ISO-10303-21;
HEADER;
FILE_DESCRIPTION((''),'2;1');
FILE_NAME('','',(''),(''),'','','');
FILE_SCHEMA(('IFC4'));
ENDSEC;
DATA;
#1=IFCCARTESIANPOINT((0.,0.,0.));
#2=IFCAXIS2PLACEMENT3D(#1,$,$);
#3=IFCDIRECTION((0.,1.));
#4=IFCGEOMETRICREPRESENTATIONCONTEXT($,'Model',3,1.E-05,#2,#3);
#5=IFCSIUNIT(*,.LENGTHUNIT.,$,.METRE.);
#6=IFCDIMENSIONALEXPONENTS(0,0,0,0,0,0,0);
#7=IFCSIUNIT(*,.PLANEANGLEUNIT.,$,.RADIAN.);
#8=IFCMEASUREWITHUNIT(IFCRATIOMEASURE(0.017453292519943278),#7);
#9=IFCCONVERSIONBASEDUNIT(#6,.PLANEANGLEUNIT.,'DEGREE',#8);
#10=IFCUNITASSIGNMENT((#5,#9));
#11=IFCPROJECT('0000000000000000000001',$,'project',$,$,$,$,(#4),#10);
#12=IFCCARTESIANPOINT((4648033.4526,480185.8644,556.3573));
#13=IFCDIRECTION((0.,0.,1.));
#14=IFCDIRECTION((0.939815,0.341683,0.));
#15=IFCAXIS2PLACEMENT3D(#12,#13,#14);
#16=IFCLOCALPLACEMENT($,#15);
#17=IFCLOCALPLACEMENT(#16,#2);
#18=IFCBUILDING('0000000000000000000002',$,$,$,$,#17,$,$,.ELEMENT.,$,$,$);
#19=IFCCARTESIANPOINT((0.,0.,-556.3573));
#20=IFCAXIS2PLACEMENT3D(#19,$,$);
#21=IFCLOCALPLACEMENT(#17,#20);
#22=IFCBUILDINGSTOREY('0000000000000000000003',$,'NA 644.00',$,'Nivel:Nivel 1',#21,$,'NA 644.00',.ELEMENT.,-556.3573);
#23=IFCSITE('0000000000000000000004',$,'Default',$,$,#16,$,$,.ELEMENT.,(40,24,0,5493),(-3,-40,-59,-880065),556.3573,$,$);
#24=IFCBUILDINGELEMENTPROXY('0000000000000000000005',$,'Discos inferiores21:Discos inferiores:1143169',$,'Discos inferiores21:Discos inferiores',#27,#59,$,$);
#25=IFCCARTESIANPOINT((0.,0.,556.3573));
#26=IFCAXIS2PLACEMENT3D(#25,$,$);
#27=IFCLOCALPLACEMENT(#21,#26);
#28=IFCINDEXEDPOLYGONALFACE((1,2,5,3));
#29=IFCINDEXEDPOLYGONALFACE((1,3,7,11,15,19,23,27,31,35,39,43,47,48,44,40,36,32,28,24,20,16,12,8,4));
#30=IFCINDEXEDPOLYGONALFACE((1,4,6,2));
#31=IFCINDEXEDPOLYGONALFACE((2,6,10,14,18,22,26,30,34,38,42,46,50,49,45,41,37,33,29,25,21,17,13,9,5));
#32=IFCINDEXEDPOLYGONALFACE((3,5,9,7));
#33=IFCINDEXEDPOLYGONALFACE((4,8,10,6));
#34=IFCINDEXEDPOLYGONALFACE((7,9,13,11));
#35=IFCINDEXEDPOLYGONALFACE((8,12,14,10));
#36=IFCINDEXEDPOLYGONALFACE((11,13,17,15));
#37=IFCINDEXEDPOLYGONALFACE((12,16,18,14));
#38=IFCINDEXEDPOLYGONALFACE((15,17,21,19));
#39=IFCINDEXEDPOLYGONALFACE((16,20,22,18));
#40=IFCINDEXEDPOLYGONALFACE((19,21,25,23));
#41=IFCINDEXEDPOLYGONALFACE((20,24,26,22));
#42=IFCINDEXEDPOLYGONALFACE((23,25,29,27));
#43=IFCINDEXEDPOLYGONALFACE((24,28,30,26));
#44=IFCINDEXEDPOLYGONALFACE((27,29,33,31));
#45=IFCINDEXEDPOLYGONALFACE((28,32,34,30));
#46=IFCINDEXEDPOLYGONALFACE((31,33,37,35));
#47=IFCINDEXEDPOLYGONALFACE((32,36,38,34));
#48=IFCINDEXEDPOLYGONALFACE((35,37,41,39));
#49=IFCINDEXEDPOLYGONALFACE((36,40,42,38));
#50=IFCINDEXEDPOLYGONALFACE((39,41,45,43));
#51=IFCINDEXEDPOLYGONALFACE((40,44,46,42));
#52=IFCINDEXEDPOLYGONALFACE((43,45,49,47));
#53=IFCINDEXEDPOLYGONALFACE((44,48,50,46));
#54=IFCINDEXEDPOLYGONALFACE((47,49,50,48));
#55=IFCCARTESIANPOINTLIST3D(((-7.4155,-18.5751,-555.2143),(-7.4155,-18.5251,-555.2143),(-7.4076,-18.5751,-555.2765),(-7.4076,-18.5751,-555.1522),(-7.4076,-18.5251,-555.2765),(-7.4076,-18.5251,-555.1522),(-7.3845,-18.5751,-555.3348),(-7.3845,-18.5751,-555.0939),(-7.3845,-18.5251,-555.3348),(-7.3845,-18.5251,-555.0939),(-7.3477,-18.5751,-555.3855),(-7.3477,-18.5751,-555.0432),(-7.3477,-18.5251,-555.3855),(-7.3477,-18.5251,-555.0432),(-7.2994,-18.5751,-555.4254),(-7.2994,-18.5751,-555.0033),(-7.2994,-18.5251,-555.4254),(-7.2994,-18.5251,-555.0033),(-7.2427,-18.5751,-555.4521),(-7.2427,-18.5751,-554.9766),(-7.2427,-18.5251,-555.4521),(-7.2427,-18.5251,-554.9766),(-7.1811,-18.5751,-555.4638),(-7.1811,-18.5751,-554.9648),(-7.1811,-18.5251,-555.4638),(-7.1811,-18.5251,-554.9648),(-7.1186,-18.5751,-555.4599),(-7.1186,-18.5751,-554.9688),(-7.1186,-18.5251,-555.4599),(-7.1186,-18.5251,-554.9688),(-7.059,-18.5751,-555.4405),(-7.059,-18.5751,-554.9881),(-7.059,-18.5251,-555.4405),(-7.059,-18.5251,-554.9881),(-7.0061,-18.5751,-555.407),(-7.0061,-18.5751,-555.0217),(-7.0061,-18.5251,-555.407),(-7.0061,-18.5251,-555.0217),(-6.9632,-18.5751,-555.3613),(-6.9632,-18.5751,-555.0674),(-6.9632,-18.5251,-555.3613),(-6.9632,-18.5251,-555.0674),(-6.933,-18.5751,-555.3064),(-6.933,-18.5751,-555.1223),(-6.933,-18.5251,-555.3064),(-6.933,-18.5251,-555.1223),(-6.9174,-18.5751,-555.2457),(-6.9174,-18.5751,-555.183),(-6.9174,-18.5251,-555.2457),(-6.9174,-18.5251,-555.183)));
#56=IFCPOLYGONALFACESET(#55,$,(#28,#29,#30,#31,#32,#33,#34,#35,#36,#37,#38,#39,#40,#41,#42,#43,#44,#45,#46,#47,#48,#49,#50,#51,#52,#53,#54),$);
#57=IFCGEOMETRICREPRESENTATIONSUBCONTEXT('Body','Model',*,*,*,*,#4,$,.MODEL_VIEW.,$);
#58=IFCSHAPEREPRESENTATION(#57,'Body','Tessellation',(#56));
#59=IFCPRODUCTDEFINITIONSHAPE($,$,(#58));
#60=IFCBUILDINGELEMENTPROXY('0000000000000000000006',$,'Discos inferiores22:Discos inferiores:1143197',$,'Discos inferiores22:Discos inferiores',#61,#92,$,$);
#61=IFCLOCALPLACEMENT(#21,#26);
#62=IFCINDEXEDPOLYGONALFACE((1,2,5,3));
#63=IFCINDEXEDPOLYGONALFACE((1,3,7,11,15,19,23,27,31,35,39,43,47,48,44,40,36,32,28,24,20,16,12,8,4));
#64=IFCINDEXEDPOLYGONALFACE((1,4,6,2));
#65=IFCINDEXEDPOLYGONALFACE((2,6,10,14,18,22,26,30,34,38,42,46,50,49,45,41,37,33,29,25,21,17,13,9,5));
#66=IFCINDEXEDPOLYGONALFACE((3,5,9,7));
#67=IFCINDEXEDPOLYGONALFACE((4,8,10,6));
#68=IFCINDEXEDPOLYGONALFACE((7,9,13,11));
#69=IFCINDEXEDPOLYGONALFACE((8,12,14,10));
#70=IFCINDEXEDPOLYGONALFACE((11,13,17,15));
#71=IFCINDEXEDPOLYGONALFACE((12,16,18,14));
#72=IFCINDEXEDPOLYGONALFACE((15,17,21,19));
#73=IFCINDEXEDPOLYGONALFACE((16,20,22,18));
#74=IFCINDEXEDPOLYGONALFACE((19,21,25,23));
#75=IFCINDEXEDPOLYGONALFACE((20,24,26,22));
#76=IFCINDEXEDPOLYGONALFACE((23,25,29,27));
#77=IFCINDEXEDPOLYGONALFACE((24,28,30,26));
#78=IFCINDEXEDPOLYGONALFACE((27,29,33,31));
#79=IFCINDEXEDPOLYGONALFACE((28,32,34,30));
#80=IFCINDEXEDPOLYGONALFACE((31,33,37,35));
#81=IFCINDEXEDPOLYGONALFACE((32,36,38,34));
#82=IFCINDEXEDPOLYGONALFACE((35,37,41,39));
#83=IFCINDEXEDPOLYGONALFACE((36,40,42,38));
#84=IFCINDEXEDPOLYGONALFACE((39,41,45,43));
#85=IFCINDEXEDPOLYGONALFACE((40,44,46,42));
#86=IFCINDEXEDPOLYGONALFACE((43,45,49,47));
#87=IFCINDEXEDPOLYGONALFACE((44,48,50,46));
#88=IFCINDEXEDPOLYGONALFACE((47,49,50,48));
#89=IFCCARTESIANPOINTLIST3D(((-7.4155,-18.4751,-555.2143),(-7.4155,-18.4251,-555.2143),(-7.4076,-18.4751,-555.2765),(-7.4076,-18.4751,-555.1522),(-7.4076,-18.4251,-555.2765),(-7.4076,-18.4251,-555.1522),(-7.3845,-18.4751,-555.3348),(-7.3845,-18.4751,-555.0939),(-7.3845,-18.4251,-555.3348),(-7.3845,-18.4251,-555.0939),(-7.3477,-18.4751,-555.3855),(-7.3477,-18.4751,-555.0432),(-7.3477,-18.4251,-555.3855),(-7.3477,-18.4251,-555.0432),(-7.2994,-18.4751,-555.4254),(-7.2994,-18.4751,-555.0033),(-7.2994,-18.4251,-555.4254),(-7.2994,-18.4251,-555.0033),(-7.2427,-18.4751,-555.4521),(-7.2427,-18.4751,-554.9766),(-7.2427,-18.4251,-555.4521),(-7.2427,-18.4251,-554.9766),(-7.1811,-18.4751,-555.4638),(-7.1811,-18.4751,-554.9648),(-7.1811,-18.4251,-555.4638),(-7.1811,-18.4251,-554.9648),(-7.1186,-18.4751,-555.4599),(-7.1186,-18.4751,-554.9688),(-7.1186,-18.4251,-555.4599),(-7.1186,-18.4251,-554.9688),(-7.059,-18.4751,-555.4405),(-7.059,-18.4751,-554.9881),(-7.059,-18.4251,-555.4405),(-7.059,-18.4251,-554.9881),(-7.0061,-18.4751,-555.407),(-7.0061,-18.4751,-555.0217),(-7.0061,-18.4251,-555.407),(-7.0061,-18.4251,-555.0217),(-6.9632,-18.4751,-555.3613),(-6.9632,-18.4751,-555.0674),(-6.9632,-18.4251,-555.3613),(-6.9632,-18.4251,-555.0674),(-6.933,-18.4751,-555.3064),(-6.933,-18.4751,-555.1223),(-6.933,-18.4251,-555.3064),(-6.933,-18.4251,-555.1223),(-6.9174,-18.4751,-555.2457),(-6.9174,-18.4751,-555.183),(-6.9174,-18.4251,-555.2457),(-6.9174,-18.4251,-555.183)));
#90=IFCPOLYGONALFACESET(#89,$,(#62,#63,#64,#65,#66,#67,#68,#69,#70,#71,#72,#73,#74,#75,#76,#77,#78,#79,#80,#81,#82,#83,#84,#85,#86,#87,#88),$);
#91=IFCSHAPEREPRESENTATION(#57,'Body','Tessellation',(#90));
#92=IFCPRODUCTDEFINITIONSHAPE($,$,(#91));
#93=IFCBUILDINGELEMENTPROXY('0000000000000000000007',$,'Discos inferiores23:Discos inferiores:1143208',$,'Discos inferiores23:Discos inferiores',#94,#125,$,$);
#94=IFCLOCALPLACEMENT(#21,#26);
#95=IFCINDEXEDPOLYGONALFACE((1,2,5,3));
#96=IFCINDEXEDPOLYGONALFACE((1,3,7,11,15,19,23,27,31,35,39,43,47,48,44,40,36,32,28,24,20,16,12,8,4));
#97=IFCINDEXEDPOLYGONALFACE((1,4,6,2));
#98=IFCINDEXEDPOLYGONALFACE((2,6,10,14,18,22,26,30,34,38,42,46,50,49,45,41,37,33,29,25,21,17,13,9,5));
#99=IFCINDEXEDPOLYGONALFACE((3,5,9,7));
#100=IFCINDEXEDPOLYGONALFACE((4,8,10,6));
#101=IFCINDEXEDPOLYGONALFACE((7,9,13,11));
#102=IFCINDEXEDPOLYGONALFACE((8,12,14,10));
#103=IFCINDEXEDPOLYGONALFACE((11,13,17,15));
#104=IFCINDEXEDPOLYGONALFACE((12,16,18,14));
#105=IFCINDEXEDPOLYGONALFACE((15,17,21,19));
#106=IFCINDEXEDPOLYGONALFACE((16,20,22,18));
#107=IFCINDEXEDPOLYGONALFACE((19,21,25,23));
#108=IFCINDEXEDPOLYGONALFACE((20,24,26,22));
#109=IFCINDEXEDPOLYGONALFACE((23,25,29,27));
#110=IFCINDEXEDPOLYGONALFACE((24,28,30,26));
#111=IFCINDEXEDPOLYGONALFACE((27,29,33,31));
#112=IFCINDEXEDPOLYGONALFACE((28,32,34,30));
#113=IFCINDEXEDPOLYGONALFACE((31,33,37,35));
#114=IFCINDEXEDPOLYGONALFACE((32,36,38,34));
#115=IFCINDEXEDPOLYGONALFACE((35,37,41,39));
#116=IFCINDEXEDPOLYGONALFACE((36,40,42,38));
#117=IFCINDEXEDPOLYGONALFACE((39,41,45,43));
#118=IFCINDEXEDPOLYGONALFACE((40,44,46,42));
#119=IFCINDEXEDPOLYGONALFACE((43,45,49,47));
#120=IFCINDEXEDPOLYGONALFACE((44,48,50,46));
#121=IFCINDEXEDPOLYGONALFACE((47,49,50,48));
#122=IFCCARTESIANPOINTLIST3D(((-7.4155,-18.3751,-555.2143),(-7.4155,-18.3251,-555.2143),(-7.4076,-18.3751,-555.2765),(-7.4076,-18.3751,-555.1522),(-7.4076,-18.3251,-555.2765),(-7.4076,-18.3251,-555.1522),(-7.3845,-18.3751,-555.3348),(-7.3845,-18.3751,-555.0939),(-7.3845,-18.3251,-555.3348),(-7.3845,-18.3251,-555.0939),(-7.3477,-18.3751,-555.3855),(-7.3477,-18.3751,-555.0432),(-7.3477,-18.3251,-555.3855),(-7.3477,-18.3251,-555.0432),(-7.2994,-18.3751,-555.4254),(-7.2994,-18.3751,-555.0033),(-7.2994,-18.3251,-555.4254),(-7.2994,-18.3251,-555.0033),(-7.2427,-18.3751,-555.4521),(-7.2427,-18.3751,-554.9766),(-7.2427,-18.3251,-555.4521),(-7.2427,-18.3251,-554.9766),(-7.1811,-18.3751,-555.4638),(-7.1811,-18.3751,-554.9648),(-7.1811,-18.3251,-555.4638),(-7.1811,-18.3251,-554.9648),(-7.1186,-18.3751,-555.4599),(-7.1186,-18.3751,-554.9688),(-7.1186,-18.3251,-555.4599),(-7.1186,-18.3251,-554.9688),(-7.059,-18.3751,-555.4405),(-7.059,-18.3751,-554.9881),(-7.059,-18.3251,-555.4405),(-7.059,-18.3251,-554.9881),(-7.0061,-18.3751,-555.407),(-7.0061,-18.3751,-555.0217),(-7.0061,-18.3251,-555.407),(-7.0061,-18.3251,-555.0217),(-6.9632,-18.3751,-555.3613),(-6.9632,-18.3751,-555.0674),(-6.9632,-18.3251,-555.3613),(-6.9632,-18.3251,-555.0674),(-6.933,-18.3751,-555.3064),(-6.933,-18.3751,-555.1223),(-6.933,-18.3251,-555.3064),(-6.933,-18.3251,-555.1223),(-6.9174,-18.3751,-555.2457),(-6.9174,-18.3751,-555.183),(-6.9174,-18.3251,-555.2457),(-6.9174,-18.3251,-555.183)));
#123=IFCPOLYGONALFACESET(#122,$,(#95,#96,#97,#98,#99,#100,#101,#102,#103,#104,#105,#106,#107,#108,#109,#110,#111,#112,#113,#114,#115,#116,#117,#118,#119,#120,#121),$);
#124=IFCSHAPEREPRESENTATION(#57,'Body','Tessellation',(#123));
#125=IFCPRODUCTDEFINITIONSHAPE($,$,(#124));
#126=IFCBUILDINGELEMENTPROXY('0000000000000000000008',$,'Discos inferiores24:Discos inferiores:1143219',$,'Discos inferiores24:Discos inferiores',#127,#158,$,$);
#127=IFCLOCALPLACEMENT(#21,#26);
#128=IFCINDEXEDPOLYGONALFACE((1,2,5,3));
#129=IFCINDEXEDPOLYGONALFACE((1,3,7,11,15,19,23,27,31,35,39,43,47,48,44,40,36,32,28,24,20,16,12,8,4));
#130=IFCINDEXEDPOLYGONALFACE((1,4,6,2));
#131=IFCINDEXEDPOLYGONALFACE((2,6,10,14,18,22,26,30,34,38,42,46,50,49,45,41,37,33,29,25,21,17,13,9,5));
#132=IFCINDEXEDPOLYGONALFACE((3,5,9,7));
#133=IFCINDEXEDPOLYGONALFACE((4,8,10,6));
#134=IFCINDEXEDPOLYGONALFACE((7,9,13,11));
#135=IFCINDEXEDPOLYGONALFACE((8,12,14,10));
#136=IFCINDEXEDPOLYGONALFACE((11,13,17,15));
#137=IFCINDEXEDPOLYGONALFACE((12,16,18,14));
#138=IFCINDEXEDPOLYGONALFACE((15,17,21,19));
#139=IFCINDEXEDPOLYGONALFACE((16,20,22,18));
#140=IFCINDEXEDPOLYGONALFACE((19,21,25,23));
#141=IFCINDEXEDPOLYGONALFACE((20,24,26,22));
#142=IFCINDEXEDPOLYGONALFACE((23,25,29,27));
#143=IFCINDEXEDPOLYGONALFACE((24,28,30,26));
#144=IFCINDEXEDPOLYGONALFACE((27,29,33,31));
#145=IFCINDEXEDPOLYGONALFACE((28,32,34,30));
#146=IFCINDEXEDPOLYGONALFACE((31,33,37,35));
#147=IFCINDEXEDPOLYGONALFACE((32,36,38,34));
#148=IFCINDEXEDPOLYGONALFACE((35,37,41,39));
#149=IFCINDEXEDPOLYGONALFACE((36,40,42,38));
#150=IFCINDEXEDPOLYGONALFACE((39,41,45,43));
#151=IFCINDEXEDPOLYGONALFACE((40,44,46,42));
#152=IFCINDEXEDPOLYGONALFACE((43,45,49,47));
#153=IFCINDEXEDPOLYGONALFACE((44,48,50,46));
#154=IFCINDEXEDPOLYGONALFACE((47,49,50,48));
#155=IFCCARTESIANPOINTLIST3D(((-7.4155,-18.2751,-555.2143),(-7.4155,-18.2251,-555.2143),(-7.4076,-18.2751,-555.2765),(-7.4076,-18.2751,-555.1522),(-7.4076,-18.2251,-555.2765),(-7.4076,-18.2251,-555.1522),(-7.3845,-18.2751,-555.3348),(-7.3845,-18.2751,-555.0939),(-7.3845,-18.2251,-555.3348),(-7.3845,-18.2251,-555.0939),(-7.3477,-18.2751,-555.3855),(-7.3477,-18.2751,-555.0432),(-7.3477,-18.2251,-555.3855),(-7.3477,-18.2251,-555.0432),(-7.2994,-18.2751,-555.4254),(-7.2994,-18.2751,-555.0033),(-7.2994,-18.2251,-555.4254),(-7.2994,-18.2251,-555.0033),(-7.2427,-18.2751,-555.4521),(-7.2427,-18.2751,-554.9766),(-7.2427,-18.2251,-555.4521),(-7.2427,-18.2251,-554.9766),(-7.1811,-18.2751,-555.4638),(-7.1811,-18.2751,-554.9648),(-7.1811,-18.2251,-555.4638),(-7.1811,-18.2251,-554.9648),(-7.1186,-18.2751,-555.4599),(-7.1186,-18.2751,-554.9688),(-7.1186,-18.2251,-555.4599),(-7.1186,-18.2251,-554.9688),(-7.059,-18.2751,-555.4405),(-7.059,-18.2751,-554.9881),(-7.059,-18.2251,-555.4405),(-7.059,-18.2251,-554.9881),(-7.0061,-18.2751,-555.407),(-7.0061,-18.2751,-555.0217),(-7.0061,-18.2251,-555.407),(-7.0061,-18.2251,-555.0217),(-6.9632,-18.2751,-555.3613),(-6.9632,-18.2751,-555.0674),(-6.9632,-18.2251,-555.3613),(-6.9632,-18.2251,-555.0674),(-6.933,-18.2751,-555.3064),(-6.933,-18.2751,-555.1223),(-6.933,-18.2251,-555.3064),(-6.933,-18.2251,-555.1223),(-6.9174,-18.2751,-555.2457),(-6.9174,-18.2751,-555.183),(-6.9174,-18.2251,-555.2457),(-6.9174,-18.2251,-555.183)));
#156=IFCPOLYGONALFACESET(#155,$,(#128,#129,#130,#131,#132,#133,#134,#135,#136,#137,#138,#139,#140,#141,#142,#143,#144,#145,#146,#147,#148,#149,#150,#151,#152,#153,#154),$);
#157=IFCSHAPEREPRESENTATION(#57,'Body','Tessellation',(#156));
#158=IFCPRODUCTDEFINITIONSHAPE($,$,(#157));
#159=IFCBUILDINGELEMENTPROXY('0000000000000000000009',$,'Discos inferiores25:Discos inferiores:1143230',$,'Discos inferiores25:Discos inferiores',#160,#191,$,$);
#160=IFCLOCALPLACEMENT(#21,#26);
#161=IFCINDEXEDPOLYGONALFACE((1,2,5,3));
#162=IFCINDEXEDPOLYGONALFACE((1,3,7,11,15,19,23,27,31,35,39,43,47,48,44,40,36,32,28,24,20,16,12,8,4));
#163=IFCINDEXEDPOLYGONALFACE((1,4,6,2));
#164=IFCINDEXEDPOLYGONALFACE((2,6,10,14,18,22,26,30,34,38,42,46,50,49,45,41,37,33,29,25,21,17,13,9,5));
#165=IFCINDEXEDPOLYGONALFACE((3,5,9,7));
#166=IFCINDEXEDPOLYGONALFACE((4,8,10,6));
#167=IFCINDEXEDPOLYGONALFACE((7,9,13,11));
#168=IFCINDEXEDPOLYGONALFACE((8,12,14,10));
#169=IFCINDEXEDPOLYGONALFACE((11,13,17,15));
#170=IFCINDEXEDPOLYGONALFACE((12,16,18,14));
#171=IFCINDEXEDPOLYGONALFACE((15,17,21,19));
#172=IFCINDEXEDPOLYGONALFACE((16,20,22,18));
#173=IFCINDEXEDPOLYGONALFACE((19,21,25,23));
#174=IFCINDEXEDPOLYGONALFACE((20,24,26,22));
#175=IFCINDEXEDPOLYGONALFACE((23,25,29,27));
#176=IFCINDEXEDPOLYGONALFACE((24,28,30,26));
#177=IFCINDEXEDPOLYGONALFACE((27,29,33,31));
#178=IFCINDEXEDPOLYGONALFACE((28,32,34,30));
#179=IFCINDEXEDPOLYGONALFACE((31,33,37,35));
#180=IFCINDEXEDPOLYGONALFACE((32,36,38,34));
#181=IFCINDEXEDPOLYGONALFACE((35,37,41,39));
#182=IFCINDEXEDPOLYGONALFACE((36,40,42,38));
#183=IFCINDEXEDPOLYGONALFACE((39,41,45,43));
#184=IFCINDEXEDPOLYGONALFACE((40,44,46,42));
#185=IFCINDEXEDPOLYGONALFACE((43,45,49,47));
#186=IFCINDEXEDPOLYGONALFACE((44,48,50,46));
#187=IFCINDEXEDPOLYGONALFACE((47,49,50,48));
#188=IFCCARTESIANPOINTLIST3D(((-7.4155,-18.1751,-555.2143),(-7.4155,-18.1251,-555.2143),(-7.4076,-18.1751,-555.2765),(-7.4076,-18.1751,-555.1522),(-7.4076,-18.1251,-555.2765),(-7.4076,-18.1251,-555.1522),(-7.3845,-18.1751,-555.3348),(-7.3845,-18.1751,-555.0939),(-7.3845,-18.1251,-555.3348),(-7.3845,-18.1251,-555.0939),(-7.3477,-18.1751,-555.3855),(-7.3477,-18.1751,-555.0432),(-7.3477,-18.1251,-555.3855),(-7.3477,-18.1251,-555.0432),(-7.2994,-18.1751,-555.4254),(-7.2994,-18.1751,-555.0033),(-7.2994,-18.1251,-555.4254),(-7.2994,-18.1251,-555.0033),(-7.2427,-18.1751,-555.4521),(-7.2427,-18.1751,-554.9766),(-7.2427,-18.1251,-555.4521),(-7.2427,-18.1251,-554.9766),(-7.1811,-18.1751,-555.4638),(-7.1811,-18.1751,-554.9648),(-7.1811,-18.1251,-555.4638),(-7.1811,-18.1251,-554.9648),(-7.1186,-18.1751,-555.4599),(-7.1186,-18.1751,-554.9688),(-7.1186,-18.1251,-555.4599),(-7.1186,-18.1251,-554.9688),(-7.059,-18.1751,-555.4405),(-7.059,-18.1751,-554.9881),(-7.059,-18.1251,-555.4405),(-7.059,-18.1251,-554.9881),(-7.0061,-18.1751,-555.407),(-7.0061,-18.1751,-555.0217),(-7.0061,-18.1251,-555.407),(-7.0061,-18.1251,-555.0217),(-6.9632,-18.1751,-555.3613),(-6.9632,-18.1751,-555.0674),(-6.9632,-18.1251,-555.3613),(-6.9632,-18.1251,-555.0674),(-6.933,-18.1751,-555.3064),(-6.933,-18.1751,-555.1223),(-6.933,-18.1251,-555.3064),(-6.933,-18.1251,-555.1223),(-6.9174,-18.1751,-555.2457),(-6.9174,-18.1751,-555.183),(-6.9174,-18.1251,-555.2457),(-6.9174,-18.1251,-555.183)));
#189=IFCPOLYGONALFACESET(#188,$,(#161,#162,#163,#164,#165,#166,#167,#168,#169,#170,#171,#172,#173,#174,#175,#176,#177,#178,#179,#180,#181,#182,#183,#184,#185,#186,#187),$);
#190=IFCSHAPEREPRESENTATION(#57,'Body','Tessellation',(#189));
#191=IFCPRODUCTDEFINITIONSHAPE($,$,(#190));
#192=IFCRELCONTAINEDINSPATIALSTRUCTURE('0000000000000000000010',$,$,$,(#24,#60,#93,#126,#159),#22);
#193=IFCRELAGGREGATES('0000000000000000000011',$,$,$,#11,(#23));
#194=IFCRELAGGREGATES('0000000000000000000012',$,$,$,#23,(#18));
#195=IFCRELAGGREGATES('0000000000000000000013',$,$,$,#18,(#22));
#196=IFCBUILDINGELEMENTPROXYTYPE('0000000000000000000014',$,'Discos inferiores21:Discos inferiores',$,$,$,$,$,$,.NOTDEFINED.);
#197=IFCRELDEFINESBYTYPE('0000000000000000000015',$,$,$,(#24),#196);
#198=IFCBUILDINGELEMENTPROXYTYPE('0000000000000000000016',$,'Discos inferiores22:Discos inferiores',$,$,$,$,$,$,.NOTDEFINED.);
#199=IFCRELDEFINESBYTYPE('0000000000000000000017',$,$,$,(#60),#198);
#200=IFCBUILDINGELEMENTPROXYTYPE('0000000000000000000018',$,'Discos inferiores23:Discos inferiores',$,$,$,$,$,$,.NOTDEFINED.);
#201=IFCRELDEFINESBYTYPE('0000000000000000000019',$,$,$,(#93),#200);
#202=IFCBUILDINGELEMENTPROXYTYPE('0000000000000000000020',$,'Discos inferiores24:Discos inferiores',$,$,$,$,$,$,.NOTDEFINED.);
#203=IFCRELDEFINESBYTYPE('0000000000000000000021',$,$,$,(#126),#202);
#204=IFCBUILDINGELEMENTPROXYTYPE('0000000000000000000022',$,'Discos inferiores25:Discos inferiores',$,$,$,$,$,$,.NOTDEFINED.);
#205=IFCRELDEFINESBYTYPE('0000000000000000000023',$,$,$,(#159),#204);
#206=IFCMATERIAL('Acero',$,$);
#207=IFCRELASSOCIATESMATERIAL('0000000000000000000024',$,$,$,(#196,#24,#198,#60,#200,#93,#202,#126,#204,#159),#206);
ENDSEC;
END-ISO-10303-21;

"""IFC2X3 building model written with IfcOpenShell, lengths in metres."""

from ifc_helpers import new_model, entity, si_unit, converted_unit, direction, frame, origin, origin_2d_with_axis, place, context, subcontext, project, spatial, circle, extrude, source, transform, mapped, material, type_object, type_shapes, element, save


model = new_model("IFC2X3")

# Units and contexts
model_context = context("Model", 3, precision=1e-05, world=origin(), true_north=direction((0.0, 1.0)))
body_context = subcontext(model_context, "Body", "Model", "MODEL_VIEW")
ifc_project = project(units=[si_unit("LENGTHUNIT", "METRE"), converted_unit("PLANEANGLEUNIT", "DEGREE", entity("IfcRatioMeasure", 0.017453292519943278), si_unit("PLANEANGLEUNIT", "RADIAN"), dimensions=[0, 0, 0, 0, 0, 0, 0])], contexts=[model_context])

# Site, building, storey
site_placement = place(None, frame((4648033.4526, 480185.8644, 556.3573), z_axis=(0.0, 0.0, 1.0), x_axis=(0.939815, 0.341683, 0.0)))
site = spatial("IfcSite", under=ifc_project, at=site_placement, Name="Default", CompositionType="ELEMENT", RefLatitude=(40, 24, 0, 5493), RefLongitude=(-3, -40, -59, -880065), RefElevation=556.3573)
building_placement = place(site_placement, origin())
building = spatial("IfcBuilding", under=site, at=building_placement, CompositionType="ELEMENT")
storey_placement = place(building_placement, frame((0.0, 0.0, -556.3573)))
storey = spatial("IfcBuildingStorey", under=building, at=storey_placement, Name="NA 644.00", ObjectType="Nivel:Nivel 1", LongName="NA 644.00", CompositionType="ELEMENT", Elevation=-556.3573)

# Building element proxies
ifc_material_1 = material(Name="Acero")
building_element_proxy_type_1 = type_object("IfcBuildingElementProxyType", Name="Discos inferiores21:Discos inferiores", PredefinedType="NOTDEFINED", material=ifc_material_1)
shared_shape_1 = source(origin(), body_context, "Body", "SweptSolid", [
    extrude(circle(Radius=0.25, at=origin_2d_with_axis()), frame((-7.1655, -18.5751, -555.2143), z_axis=(0.0, 1.0, 0.0), x_axis=(-1.0, 0.0, 0.0)), (0.0, 0.0, 1.0), 0.05),
])
type_shapes(building_element_proxy_type_1, [shared_shape_1])
proxy_1_placement = place(storey_placement, frame((0.0, 0.0, 556.3573)))
element("IfcBuildingElementProxy", 1, at=proxy_1_placement, inside=storey, type_object=building_element_proxy_type_1, material=ifc_material_1, Name="Discos inferiores21:Discos inferiores:1143169", ObjectType="Discos inferiores21:Discos inferiores", context=body_context, shape_type="MappedRepresentation", body=[
    mapped(shared_shape_1, transform((0.0, 0.0, 0.0), scale=1.0)),
])
building_element_proxy_type_2 = type_object("IfcBuildingElementProxyType", Name="Discos inferiores22:Discos inferiores", PredefinedType="NOTDEFINED", material=ifc_material_1)
shared_shape_2 = source(origin(), body_context, "Body", "SweptSolid", [
    extrude(circle(Radius=0.25, at=origin_2d_with_axis()), frame((-7.1655, -18.4751, -555.2143), z_axis=(0.0, 1.0, 0.0), x_axis=(-1.0, 0.0, 0.0)), (0.0, 0.0, 1.0), 0.05),
])
type_shapes(building_element_proxy_type_2, [shared_shape_2])
proxy_2_placement = place(storey_placement, frame((0.0, 0.0, 556.3573)))
element("IfcBuildingElementProxy", 2, at=proxy_2_placement, inside=storey, type_object=building_element_proxy_type_2, material=ifc_material_1, Name="Discos inferiores22:Discos inferiores:1143197", ObjectType="Discos inferiores22:Discos inferiores", context=body_context, shape_type="MappedRepresentation", body=[
    mapped(shared_shape_2, transform((0.0, 0.0, 0.0), scale=1.0)),
])
building_element_proxy_type_3 = type_object("IfcBuildingElementProxyType", Name="Discos inferiores23:Discos inferiores", PredefinedType="NOTDEFINED", material=ifc_material_1)
shared_shape_3 = source(origin(), body_context, "Body", "SweptSolid", [
    extrude(circle(Radius=0.25, at=origin_2d_with_axis()), frame((-7.1655, -18.3751, -555.2143), z_axis=(0.0, 1.0, 0.0), x_axis=(-1.0, 0.0, 0.0)), (0.0, 0.0, 1.0), 0.05),
])
type_shapes(building_element_proxy_type_3, [shared_shape_3])
proxy_3_placement = place(storey_placement, frame((0.0, 0.0, 556.3573)))
element("IfcBuildingElementProxy", 3, at=proxy_3_placement, inside=storey, type_object=building_element_proxy_type_3, material=ifc_material_1, Name="Discos inferiores23:Discos inferiores:1143208", ObjectType="Discos inferiores23:Discos inferiores", context=body_context, shape_type="MappedRepresentation", body=[
    mapped(shared_shape_3, transform((0.0, 0.0, 0.0), scale=1.0)),
])
building_element_proxy_type_4 = type_object("IfcBuildingElementProxyType", Name="Discos inferiores24:Discos inferiores", PredefinedType="NOTDEFINED", material=ifc_material_1)
shared_shape_4 = source(origin(), body_context, "Body", "SweptSolid", [
    extrude(circle(Radius=0.25, at=origin_2d_with_axis()), frame((-7.1655, -18.2751, -555.2143), z_axis=(0.0, 1.0, 0.0), x_axis=(-1.0, 0.0, 0.0)), (0.0, 0.0, 1.0), 0.05),
])
type_shapes(building_element_proxy_type_4, [shared_shape_4])
proxy_4_placement = place(storey_placement, frame((0.0, 0.0, 556.3573)))
element("IfcBuildingElementProxy", 4, at=proxy_4_placement, inside=storey, type_object=building_element_proxy_type_4, material=ifc_material_1, Name="Discos inferiores24:Discos inferiores:1143219", ObjectType="Discos inferiores24:Discos inferiores", context=body_context, shape_type="MappedRepresentation", body=[
    mapped(shared_shape_4, transform((0.0, 0.0, 0.0), scale=1.0)),
])
building_element_proxy_type_5 = type_object("IfcBuildingElementProxyType", Name="Discos inferiores25:Discos inferiores", PredefinedType="NOTDEFINED", material=ifc_material_1)
shared_shape_5 = source(origin(), body_context, "Body", "SweptSolid", [
    extrude(circle(Radius=0.25, at=origin_2d_with_axis()), frame((-7.1655, -18.1751, -555.2143), z_axis=(0.0, 1.0, 0.0), x_axis=(-1.0, 0.0, 0.0)), (0.0, 0.0, 1.0), 0.05),
])
type_shapes(building_element_proxy_type_5, [shared_shape_5])
proxy_5_placement = place(storey_placement, frame((0.0, 0.0, 556.3573)))
element("IfcBuildingElementProxy", 5, at=proxy_5_placement, inside=storey, type_object=building_element_proxy_type_5, material=ifc_material_1, Name="Discos inferiores25:Discos inferiores:1143230", ObjectType="Discos inferiores25:Discos inferiores", context=body_context, shape_type="MappedRepresentation", body=[
    mapped(shared_shape_5, transform((0.0, 0.0, 0.0), scale=1.0)),
])

save(model, "model.ifc")
